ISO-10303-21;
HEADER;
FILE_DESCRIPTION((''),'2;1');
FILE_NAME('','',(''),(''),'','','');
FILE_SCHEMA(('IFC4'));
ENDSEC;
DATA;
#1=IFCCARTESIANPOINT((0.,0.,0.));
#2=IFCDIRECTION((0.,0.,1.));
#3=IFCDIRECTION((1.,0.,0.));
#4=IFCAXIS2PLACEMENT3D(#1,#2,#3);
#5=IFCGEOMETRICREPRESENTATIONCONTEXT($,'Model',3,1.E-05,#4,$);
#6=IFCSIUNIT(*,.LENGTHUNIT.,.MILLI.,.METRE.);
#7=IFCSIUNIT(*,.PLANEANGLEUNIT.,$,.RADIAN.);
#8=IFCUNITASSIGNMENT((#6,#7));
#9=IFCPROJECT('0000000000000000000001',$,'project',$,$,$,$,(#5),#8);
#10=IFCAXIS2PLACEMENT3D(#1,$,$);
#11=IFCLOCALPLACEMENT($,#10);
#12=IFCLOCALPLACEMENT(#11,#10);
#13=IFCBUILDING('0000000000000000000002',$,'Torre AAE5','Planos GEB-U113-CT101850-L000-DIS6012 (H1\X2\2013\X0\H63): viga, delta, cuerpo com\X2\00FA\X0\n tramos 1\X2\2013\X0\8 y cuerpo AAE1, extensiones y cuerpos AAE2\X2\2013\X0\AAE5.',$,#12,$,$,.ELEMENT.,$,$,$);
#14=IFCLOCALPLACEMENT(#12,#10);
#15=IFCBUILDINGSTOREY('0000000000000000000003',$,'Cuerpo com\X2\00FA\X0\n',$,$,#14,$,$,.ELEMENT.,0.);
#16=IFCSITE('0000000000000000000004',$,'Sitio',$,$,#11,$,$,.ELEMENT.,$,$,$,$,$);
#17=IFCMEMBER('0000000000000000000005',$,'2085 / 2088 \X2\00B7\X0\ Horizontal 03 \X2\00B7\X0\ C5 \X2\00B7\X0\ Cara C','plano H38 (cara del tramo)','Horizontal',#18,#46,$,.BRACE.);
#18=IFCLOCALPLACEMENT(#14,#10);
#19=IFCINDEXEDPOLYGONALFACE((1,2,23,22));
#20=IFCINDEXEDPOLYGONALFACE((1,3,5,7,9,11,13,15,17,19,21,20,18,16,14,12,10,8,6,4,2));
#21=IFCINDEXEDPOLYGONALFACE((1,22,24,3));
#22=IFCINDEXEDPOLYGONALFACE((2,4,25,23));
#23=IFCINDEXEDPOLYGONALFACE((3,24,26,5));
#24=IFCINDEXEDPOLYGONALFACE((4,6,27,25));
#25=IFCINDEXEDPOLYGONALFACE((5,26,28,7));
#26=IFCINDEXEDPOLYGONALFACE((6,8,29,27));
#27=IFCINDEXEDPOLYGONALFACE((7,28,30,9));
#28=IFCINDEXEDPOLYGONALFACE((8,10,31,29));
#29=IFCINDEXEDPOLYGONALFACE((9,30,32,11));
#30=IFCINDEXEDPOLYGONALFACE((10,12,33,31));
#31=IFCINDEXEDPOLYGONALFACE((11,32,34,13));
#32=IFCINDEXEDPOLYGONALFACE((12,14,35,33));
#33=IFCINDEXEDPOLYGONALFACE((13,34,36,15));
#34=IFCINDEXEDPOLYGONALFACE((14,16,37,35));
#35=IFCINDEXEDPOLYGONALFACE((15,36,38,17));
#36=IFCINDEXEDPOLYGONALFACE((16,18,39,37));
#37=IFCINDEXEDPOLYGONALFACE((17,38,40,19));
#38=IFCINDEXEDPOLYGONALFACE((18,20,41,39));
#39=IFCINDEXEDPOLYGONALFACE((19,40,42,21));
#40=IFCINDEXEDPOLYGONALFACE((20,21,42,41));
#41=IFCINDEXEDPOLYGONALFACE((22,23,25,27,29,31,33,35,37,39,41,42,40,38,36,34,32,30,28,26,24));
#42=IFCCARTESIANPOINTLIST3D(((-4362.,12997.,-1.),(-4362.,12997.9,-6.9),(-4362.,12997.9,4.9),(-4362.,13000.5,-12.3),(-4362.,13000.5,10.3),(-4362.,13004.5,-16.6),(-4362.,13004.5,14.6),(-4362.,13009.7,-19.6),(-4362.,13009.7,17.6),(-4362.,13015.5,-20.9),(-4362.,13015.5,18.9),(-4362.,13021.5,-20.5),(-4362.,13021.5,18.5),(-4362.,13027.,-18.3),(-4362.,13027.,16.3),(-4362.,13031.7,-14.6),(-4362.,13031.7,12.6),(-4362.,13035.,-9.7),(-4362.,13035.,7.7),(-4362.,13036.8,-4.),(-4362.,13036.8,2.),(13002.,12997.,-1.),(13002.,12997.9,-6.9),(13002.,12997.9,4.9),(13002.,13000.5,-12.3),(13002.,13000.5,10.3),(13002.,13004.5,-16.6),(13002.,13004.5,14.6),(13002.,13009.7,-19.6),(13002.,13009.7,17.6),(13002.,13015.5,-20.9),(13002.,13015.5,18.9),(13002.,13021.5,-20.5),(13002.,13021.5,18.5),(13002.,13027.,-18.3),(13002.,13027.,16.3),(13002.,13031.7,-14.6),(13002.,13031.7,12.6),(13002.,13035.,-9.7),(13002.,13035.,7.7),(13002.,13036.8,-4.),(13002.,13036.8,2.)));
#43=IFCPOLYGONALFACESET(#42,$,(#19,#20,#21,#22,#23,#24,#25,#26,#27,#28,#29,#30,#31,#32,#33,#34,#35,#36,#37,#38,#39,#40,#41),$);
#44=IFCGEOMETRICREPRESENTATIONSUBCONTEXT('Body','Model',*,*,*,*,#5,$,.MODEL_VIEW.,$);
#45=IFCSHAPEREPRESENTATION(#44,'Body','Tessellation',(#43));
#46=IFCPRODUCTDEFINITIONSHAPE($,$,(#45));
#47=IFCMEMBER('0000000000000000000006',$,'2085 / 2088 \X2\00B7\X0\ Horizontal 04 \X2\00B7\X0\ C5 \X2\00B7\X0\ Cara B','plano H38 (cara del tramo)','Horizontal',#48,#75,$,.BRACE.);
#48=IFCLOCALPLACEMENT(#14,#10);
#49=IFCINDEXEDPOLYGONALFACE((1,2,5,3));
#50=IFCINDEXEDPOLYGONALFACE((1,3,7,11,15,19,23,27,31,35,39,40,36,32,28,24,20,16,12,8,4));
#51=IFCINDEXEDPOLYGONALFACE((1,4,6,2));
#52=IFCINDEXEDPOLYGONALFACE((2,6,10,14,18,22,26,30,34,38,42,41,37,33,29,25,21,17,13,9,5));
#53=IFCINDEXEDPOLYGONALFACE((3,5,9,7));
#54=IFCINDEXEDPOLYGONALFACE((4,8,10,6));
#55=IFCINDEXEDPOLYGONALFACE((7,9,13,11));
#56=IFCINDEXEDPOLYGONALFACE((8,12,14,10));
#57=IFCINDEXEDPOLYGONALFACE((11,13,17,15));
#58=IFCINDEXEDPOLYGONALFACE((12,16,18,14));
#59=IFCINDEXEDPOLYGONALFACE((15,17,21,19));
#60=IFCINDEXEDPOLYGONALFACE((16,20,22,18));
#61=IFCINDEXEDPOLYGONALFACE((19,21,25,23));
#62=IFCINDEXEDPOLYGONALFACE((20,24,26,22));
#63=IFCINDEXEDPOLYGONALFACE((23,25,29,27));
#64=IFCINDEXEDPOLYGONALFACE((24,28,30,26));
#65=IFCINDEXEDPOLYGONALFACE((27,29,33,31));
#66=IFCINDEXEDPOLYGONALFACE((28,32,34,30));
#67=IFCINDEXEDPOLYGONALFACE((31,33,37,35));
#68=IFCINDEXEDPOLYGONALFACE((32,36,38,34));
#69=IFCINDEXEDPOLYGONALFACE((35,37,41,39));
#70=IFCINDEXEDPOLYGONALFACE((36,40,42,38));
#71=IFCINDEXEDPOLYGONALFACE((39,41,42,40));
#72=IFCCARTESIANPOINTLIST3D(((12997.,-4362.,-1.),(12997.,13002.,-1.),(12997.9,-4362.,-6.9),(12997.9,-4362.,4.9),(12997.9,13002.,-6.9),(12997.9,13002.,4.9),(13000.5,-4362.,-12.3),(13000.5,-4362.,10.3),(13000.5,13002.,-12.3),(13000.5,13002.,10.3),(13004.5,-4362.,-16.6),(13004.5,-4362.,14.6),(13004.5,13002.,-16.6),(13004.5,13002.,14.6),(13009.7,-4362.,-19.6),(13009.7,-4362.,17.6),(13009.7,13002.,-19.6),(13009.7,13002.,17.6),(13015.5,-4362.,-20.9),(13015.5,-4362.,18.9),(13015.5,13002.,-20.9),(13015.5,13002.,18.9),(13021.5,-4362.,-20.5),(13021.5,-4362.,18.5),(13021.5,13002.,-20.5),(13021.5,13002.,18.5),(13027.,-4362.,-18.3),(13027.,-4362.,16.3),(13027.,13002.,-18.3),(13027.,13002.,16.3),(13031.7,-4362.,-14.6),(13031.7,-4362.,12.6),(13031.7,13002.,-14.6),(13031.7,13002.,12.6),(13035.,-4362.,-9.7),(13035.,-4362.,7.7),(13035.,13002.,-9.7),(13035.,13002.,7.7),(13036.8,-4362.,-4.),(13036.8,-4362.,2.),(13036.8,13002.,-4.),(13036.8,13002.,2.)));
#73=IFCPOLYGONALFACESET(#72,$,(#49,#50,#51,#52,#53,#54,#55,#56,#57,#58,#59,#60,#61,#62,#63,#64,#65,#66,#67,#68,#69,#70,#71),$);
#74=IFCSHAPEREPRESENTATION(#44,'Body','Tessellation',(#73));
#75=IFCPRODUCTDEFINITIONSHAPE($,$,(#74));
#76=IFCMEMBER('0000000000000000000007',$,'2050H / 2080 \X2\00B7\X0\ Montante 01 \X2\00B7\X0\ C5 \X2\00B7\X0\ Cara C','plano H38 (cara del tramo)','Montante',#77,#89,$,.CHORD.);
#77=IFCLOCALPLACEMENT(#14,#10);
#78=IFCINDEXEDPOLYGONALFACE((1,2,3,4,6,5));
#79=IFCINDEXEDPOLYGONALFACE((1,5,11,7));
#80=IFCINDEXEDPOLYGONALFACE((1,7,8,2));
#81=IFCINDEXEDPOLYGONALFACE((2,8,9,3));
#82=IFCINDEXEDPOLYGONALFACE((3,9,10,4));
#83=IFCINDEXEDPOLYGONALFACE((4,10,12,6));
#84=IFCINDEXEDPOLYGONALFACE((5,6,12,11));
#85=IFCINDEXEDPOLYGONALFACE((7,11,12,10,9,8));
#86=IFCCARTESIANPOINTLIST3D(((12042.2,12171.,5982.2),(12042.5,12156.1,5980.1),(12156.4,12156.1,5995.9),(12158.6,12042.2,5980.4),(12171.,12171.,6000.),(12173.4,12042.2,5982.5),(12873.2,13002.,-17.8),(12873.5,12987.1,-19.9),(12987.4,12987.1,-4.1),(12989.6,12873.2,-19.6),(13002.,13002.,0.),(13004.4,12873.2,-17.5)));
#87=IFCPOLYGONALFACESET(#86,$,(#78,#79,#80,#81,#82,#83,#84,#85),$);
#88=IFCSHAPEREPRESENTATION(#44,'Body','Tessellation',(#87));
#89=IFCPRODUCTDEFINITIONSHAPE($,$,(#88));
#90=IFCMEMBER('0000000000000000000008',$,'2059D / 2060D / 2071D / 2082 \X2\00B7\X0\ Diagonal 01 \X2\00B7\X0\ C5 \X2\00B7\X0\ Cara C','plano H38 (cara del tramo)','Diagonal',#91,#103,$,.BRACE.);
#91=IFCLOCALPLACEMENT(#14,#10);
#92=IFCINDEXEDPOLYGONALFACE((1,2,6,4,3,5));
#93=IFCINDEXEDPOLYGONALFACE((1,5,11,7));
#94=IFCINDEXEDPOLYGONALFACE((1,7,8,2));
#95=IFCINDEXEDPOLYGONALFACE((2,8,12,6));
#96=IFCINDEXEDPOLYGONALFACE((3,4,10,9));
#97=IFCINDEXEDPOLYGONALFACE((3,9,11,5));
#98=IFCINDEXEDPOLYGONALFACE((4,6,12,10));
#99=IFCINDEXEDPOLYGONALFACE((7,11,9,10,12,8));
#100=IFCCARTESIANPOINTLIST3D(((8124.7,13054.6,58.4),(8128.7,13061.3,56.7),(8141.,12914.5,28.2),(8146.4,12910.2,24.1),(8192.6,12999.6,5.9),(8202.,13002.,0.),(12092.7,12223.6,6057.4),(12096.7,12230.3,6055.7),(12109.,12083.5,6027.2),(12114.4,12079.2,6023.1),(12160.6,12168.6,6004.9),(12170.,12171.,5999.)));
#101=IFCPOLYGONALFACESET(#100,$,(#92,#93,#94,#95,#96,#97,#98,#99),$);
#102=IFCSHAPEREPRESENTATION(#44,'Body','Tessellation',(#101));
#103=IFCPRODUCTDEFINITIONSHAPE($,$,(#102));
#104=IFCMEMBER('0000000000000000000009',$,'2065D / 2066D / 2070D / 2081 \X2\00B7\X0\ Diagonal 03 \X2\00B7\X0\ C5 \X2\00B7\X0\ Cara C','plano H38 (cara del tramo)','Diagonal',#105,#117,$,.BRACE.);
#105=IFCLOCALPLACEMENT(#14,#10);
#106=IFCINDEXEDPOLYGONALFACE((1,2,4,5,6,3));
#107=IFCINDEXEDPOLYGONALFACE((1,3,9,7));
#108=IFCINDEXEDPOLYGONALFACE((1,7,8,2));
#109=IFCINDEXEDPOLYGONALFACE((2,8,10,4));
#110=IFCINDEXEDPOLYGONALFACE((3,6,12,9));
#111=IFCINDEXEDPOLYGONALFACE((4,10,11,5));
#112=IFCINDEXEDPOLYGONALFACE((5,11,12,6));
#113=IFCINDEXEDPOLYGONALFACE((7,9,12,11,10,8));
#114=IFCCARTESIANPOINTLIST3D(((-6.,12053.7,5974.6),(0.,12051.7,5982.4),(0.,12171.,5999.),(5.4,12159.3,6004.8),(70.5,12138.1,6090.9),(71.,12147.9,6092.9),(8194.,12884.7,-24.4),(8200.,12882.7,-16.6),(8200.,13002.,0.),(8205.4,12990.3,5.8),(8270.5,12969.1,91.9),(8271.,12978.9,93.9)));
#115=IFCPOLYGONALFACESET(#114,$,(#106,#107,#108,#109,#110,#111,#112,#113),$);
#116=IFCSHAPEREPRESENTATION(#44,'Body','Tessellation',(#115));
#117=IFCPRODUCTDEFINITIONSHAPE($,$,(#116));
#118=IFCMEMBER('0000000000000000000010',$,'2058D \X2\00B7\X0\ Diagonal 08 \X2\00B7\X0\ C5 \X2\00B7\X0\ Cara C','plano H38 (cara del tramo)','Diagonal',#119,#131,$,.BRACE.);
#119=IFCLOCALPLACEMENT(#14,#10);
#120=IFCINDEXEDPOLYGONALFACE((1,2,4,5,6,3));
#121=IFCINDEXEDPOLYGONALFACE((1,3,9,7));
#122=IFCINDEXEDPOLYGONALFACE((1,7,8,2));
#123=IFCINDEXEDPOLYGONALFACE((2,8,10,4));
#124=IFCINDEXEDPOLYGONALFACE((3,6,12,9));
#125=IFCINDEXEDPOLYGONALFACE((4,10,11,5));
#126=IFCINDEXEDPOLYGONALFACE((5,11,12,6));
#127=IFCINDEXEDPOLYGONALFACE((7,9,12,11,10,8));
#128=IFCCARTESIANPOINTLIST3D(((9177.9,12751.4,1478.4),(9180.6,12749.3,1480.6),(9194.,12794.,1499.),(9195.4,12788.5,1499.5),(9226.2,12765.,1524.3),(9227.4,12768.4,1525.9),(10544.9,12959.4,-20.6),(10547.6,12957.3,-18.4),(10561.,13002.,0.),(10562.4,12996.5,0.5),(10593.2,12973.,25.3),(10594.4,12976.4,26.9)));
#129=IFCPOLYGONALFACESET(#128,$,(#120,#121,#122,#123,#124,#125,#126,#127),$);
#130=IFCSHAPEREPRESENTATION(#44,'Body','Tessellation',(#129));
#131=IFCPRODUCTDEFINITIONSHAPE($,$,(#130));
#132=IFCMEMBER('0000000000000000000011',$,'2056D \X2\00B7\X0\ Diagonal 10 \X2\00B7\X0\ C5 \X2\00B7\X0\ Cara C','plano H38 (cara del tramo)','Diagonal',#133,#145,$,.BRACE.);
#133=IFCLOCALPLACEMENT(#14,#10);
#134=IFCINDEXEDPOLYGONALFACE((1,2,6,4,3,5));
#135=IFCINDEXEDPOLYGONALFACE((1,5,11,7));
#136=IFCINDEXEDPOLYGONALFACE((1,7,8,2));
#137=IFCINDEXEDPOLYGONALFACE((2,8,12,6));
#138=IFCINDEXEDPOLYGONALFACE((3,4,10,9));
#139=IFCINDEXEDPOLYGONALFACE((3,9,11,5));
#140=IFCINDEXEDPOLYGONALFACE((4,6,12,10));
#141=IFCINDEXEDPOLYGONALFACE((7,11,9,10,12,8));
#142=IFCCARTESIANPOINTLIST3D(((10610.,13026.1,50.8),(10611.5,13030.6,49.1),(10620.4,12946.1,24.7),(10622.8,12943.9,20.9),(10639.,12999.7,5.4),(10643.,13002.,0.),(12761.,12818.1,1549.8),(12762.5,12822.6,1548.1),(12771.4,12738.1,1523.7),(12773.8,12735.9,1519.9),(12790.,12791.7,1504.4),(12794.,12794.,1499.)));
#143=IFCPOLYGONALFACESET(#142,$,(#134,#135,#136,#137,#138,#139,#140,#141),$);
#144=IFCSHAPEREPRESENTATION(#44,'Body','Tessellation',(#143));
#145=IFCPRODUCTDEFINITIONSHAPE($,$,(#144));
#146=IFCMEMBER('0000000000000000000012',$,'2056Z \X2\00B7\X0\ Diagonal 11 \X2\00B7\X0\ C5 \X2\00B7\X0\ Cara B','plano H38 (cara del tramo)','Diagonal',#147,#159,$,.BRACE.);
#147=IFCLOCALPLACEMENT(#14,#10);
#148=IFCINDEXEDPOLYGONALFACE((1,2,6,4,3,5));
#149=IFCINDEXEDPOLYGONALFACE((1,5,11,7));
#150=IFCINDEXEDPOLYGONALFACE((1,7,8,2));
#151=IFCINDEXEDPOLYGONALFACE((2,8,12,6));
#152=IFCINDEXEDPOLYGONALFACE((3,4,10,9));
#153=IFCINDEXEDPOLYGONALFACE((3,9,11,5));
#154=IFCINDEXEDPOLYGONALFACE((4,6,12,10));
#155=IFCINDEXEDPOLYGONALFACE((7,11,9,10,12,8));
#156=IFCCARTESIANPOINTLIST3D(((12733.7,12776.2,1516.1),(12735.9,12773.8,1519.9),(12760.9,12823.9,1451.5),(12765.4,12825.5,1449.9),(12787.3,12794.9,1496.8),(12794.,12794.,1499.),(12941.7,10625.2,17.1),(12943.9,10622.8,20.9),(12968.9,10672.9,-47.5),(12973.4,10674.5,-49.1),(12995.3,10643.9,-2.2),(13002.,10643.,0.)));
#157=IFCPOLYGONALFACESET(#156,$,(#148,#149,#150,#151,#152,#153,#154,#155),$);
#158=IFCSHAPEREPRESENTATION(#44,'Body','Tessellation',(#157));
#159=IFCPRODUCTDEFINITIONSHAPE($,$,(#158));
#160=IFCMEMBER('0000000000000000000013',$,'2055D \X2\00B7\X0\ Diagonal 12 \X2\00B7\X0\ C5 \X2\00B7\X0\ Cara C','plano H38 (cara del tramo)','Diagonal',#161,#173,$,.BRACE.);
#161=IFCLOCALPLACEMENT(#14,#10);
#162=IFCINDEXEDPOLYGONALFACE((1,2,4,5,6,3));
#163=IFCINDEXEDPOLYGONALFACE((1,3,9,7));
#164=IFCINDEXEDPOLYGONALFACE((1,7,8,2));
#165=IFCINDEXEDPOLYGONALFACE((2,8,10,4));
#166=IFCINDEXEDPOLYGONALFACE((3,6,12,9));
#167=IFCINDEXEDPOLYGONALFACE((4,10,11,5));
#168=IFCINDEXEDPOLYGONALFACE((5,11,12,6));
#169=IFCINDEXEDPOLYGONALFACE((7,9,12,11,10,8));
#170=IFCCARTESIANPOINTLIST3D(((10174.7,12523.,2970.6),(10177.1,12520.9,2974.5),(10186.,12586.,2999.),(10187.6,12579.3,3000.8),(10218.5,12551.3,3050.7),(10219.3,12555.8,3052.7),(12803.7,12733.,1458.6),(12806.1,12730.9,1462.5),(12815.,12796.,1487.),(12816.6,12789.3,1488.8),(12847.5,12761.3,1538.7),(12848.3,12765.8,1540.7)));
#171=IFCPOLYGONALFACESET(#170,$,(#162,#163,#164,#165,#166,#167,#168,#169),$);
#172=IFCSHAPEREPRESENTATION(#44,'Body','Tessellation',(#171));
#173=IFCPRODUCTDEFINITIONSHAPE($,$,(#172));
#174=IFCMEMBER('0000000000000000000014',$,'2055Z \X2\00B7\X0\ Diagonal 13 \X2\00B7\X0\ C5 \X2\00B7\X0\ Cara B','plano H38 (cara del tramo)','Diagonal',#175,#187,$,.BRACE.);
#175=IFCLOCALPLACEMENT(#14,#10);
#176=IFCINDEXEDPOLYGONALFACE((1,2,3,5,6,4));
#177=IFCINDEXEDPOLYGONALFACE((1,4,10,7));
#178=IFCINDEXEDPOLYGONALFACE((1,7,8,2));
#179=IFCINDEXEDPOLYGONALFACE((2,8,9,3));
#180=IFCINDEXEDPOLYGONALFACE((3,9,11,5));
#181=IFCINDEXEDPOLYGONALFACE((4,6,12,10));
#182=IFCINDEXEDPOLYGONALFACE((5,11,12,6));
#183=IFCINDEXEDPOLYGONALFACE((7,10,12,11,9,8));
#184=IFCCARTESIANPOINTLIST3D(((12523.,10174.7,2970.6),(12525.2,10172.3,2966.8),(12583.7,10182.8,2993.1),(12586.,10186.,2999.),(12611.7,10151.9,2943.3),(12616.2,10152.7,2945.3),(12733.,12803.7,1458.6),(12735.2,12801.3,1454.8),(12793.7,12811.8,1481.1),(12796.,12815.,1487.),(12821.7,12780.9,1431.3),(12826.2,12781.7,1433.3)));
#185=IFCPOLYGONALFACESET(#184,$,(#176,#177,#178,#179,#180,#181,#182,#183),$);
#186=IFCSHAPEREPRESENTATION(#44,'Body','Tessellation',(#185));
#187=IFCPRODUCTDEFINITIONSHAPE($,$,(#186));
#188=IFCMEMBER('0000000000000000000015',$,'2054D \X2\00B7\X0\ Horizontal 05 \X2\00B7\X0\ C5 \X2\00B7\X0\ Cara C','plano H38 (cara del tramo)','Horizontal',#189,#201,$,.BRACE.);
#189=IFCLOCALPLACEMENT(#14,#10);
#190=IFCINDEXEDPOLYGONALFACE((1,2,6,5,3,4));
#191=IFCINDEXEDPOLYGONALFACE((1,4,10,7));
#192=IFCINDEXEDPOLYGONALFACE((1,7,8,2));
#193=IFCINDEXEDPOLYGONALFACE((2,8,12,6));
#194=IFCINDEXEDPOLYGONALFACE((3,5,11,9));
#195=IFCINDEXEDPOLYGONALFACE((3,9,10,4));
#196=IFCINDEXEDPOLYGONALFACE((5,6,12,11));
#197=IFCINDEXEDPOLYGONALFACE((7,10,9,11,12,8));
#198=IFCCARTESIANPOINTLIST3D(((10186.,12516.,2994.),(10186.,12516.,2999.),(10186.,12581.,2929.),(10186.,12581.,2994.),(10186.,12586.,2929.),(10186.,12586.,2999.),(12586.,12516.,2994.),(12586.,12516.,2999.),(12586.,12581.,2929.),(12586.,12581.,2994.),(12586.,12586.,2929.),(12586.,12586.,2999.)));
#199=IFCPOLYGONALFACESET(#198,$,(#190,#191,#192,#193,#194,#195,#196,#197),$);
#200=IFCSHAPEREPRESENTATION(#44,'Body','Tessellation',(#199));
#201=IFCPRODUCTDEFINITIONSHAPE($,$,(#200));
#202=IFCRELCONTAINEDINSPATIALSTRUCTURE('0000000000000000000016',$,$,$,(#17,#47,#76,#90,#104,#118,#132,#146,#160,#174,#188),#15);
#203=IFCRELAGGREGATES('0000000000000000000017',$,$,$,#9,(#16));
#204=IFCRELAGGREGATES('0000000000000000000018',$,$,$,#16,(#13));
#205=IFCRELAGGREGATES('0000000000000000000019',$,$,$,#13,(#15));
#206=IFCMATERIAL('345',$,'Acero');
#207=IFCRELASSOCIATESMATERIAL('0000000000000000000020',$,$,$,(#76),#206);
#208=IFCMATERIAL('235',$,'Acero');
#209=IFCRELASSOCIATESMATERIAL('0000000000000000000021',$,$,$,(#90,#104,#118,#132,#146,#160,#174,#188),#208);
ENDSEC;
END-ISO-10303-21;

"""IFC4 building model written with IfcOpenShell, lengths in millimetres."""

from ifc_helpers import new_model, si_unit, frame, frame_2d, origin, origin_with_axes, place, context, subcontext, project, spatial, circle, l_section, extrude, material, element, save


model = new_model("IFC4")

# Units and contexts
model_context = context("Model", 3, precision=1e-05, world=origin_with_axes())
body_context = subcontext(model_context, "Body", "Model", "MODEL_VIEW")
ifc_project = project(units=[si_unit("LENGTHUNIT", "METRE", prefix="MILLI"), si_unit("PLANEANGLEUNIT", "RADIAN")], contexts=[model_context])

# Site, building, storey
site_placement = place(None, origin())
site = spatial("IfcSite", under=ifc_project, at=site_placement, Name="Sitio", CompositionType="ELEMENT")
building_placement = place(site_placement, origin())
building = spatial("IfcBuilding", under=site, at=building_placement, Name="Torre AAE5", Description="Planos GEB-U113-CT101850-L000-DIS6012 (H1–H63): viga, delta, cuerpo común tramos 1–8 y cuerpo AAE1, extensiones y cuerpos AAE2–AAE5.", CompositionType="ELEMENT")
storey_placement = place(building_placement, origin())
storey = spatial("IfcBuildingStorey", under=building, at=storey_placement, Name="Cuerpo común", CompositionType="ELEMENT", Elevation=0.0)

# Members
for number, where, z_axis, x_axis, name in (
    (1, (13002.0, 13017.0, -1.0), (-1.0, 0.0, 0.0), (0.0, -1.0, 0.0), "2085 / 2088 · Horizontal 03 · C5 · Cara C"),
    (2, (13017.0, 13002.0, -1.0), (0.0, -1.0, 0.0), (-1.0, 0.0, 0.0), "2085 / 2088 · Horizontal 04 · C5 · Cara B"),
):
    element("IfcMember", number, at=place(storey_placement, frame(where, z_axis=z_axis, x_axis=x_axis)), inside=storey, Name=name, Description="plano H38 (cara del tramo)", ObjectType="Horizontal", PredefinedType="BRACE", context=body_context, shape_type="SweptSolid", body=[
        extrude(circle(Radius=20.0), None, (0.0, 0.0, 1.0), 17364.0),
    ])
ifc_material_1 = material(Name="345", Category="Acero")
member_1_placement = place(storey_placement, frame((12171.0, 12171.0, 6000.0), z_axis=(0.135917, 0.135917, -0.981353), x_axis=(0.018647, -0.99072, -0.134632)))
element("IfcMember", 3, at=member_1_placement, inside=storey, material=ifc_material_1, Name="2050H / 2080 · Montante 01 · C5 · Cara C", Description="plano H38 (cara del tramo)", ObjectType="Montante", PredefinedType="CHORD", context=body_context, shape_type="SweptSolid", body=[
    extrude(l_section(Depth=130.0, Width=130.0, Thickness=15.0, at=frame_2d((65.0, 65.0))), None, (0.0, 0.0, 1.0), 6114.0),
])
ifc_material_2 = material(Name="235", Category="Acero")
member_2_placement = place(storey_placement, frame((12170.0, 12171.0, 5999.0), z_axis=(-0.548035, 0.114772, -0.828544), x_axis=(-0.505832, -0.83437, 0.219)))
element("IfcMember", 4, at=member_2_placement, inside=storey, material=ifc_material_2, Name="2059D / 2060D / 2071D / 2082 · Diagonal 01 · C5 · Cara C", Description="plano H38 (cara del tramo)", ObjectType="Diagonal", PredefinedType="BRACE", context=body_context, shape_type="SweptSolid", body=[
    extrude(l_section(Depth=110.0, Width=110.0, Thickness=8.0, at=frame_2d((55.0, 55.0))), None, (0.0, 0.0, 1.0), 7240.4),
])
member_3_placement = place(storey_placement, frame((8200.0, 13002.0, 0.0), z_axis=(-0.804391, -0.081518, 0.588481), x_axis=(-0.049698, -0.977837, -0.203385)))
element("IfcMember", 5, at=member_3_placement, inside=storey, material=ifc_material_2, Name="2065D / 2066D / 2070D / 2081 · Diagonal 03 · C5 · Cara C", Description="plano H38 (cara del tramo)", ObjectType="Diagonal", PredefinedType="BRACE", context=body_context, shape_type="SweptSolid", body=[
    extrude(l_section(Depth=120.0, Width=120.0, Thickness=10.0, at=frame_2d((60.0, 60.0))), None, (0.0, 0.0, 1.0), 10194.0),
])
member_4_placement = place(storey_placement, frame((10561.0, 13002.0, 0.0), z_axis=(-0.670311, -0.101993, 0.735038), x_axis=(-0.321518, -0.852797, -0.411539)))
element("IfcMember", 6, at=member_4_placement, inside=storey, material=ifc_material_2, Name="2058D · Diagonal 08 · C5 · Cara C", Description="plano H38 (cara del tramo)", ObjectType="Diagonal", PredefinedType="BRACE", context=body_context, shape_type="SweptSolid", body=[
    extrude(l_section(Depth=50.0, Width=50.0, Thickness=4.0, at=frame_2d((25.0, 25.0))), None, (0.0, 0.0, 1.0), 2039.4),
])
for number, where, z_axis, x_axis, name in (
    (7, (12794.0, 12794.0, 1499.0), (-0.817861, 0.079087, -0.569955), (-0.310623, -0.89447, 0.321615), "2056D · Diagonal 10 · C5 · Cara C"),
    (8, (12794.0, 12794.0, 1499.0), (0.079087, -0.817861, -0.569955), (-0.89447, -0.310623, 0.321615), "2056Z · Diagonal 11 · C5 · Cara B"),
):
    element("IfcMember", number, at=place(storey_placement, frame(where, z_axis=z_axis, x_axis=x_axis)), inside=storey, material=ifc_material_2, Name=name, Description="plano H38 (cara del tramo)", ObjectType="Diagonal", PredefinedType="BRACE", context=body_context, shape_type="SweptSolid", body=[
        extrude(l_section(Depth=65.0, Width=65.0, Thickness=5.0, at=frame_2d((32.5, 32.5))), None, (0.0, 0.0, 1.0), 2630.0),
    ])
for number, where, z_axis, x_axis, name in (
    (9, (12815.0, 12796.0, 1487.0), (-0.864789, -0.069078, 0.497361), (-0.161336, -0.89975, -0.405489), "2055D · Diagonal 12 · C5 · Cara C"),
    (10, (12796.0, 12815.0, 1487.0), (-0.069078, -0.864789, 0.497361), (-0.89975, -0.161336, -0.405489), "2055Z · Diagonal 13 · C5 · Cara B"),
):
    element("IfcMember", number, at=place(storey_placement, frame(where, z_axis=z_axis, x_axis=x_axis)), inside=storey, material=ifc_material_2, Name=name, Description="plano H38 (cara del tramo)", ObjectType="Diagonal", PredefinedType="BRACE", context=body_context, shape_type="SweptSolid", body=[
        extrude(l_section(Depth=70.0, Width=70.0, Thickness=5.0, at=frame_2d((35.0, 35.0))), None, (0.0, 0.0, 1.0), 3040.0),
    ])
member_5_placement = place(storey_placement, frame((10186.0, 12586.0, 2999.0), z_axis=(1.0, 0.0, 0.0), x_axis=(0.0, -1.0, 0.0)))
element("IfcMember", 11, at=member_5_placement, inside=storey, material=ifc_material_2, Name="2054D · Horizontal 05 · C5 · Cara C", Description="plano H38 (cara del tramo)", ObjectType="Horizontal", PredefinedType="BRACE", context=body_context, shape_type="SweptSolid", body=[
    extrude(l_section(Depth=70.0, Width=70.0, Thickness=5.0, at=frame_2d((35.0, 35.0))), None, (0.0, 0.0, 1.0), 2400.0),
])

save(model, "model.ifc")
